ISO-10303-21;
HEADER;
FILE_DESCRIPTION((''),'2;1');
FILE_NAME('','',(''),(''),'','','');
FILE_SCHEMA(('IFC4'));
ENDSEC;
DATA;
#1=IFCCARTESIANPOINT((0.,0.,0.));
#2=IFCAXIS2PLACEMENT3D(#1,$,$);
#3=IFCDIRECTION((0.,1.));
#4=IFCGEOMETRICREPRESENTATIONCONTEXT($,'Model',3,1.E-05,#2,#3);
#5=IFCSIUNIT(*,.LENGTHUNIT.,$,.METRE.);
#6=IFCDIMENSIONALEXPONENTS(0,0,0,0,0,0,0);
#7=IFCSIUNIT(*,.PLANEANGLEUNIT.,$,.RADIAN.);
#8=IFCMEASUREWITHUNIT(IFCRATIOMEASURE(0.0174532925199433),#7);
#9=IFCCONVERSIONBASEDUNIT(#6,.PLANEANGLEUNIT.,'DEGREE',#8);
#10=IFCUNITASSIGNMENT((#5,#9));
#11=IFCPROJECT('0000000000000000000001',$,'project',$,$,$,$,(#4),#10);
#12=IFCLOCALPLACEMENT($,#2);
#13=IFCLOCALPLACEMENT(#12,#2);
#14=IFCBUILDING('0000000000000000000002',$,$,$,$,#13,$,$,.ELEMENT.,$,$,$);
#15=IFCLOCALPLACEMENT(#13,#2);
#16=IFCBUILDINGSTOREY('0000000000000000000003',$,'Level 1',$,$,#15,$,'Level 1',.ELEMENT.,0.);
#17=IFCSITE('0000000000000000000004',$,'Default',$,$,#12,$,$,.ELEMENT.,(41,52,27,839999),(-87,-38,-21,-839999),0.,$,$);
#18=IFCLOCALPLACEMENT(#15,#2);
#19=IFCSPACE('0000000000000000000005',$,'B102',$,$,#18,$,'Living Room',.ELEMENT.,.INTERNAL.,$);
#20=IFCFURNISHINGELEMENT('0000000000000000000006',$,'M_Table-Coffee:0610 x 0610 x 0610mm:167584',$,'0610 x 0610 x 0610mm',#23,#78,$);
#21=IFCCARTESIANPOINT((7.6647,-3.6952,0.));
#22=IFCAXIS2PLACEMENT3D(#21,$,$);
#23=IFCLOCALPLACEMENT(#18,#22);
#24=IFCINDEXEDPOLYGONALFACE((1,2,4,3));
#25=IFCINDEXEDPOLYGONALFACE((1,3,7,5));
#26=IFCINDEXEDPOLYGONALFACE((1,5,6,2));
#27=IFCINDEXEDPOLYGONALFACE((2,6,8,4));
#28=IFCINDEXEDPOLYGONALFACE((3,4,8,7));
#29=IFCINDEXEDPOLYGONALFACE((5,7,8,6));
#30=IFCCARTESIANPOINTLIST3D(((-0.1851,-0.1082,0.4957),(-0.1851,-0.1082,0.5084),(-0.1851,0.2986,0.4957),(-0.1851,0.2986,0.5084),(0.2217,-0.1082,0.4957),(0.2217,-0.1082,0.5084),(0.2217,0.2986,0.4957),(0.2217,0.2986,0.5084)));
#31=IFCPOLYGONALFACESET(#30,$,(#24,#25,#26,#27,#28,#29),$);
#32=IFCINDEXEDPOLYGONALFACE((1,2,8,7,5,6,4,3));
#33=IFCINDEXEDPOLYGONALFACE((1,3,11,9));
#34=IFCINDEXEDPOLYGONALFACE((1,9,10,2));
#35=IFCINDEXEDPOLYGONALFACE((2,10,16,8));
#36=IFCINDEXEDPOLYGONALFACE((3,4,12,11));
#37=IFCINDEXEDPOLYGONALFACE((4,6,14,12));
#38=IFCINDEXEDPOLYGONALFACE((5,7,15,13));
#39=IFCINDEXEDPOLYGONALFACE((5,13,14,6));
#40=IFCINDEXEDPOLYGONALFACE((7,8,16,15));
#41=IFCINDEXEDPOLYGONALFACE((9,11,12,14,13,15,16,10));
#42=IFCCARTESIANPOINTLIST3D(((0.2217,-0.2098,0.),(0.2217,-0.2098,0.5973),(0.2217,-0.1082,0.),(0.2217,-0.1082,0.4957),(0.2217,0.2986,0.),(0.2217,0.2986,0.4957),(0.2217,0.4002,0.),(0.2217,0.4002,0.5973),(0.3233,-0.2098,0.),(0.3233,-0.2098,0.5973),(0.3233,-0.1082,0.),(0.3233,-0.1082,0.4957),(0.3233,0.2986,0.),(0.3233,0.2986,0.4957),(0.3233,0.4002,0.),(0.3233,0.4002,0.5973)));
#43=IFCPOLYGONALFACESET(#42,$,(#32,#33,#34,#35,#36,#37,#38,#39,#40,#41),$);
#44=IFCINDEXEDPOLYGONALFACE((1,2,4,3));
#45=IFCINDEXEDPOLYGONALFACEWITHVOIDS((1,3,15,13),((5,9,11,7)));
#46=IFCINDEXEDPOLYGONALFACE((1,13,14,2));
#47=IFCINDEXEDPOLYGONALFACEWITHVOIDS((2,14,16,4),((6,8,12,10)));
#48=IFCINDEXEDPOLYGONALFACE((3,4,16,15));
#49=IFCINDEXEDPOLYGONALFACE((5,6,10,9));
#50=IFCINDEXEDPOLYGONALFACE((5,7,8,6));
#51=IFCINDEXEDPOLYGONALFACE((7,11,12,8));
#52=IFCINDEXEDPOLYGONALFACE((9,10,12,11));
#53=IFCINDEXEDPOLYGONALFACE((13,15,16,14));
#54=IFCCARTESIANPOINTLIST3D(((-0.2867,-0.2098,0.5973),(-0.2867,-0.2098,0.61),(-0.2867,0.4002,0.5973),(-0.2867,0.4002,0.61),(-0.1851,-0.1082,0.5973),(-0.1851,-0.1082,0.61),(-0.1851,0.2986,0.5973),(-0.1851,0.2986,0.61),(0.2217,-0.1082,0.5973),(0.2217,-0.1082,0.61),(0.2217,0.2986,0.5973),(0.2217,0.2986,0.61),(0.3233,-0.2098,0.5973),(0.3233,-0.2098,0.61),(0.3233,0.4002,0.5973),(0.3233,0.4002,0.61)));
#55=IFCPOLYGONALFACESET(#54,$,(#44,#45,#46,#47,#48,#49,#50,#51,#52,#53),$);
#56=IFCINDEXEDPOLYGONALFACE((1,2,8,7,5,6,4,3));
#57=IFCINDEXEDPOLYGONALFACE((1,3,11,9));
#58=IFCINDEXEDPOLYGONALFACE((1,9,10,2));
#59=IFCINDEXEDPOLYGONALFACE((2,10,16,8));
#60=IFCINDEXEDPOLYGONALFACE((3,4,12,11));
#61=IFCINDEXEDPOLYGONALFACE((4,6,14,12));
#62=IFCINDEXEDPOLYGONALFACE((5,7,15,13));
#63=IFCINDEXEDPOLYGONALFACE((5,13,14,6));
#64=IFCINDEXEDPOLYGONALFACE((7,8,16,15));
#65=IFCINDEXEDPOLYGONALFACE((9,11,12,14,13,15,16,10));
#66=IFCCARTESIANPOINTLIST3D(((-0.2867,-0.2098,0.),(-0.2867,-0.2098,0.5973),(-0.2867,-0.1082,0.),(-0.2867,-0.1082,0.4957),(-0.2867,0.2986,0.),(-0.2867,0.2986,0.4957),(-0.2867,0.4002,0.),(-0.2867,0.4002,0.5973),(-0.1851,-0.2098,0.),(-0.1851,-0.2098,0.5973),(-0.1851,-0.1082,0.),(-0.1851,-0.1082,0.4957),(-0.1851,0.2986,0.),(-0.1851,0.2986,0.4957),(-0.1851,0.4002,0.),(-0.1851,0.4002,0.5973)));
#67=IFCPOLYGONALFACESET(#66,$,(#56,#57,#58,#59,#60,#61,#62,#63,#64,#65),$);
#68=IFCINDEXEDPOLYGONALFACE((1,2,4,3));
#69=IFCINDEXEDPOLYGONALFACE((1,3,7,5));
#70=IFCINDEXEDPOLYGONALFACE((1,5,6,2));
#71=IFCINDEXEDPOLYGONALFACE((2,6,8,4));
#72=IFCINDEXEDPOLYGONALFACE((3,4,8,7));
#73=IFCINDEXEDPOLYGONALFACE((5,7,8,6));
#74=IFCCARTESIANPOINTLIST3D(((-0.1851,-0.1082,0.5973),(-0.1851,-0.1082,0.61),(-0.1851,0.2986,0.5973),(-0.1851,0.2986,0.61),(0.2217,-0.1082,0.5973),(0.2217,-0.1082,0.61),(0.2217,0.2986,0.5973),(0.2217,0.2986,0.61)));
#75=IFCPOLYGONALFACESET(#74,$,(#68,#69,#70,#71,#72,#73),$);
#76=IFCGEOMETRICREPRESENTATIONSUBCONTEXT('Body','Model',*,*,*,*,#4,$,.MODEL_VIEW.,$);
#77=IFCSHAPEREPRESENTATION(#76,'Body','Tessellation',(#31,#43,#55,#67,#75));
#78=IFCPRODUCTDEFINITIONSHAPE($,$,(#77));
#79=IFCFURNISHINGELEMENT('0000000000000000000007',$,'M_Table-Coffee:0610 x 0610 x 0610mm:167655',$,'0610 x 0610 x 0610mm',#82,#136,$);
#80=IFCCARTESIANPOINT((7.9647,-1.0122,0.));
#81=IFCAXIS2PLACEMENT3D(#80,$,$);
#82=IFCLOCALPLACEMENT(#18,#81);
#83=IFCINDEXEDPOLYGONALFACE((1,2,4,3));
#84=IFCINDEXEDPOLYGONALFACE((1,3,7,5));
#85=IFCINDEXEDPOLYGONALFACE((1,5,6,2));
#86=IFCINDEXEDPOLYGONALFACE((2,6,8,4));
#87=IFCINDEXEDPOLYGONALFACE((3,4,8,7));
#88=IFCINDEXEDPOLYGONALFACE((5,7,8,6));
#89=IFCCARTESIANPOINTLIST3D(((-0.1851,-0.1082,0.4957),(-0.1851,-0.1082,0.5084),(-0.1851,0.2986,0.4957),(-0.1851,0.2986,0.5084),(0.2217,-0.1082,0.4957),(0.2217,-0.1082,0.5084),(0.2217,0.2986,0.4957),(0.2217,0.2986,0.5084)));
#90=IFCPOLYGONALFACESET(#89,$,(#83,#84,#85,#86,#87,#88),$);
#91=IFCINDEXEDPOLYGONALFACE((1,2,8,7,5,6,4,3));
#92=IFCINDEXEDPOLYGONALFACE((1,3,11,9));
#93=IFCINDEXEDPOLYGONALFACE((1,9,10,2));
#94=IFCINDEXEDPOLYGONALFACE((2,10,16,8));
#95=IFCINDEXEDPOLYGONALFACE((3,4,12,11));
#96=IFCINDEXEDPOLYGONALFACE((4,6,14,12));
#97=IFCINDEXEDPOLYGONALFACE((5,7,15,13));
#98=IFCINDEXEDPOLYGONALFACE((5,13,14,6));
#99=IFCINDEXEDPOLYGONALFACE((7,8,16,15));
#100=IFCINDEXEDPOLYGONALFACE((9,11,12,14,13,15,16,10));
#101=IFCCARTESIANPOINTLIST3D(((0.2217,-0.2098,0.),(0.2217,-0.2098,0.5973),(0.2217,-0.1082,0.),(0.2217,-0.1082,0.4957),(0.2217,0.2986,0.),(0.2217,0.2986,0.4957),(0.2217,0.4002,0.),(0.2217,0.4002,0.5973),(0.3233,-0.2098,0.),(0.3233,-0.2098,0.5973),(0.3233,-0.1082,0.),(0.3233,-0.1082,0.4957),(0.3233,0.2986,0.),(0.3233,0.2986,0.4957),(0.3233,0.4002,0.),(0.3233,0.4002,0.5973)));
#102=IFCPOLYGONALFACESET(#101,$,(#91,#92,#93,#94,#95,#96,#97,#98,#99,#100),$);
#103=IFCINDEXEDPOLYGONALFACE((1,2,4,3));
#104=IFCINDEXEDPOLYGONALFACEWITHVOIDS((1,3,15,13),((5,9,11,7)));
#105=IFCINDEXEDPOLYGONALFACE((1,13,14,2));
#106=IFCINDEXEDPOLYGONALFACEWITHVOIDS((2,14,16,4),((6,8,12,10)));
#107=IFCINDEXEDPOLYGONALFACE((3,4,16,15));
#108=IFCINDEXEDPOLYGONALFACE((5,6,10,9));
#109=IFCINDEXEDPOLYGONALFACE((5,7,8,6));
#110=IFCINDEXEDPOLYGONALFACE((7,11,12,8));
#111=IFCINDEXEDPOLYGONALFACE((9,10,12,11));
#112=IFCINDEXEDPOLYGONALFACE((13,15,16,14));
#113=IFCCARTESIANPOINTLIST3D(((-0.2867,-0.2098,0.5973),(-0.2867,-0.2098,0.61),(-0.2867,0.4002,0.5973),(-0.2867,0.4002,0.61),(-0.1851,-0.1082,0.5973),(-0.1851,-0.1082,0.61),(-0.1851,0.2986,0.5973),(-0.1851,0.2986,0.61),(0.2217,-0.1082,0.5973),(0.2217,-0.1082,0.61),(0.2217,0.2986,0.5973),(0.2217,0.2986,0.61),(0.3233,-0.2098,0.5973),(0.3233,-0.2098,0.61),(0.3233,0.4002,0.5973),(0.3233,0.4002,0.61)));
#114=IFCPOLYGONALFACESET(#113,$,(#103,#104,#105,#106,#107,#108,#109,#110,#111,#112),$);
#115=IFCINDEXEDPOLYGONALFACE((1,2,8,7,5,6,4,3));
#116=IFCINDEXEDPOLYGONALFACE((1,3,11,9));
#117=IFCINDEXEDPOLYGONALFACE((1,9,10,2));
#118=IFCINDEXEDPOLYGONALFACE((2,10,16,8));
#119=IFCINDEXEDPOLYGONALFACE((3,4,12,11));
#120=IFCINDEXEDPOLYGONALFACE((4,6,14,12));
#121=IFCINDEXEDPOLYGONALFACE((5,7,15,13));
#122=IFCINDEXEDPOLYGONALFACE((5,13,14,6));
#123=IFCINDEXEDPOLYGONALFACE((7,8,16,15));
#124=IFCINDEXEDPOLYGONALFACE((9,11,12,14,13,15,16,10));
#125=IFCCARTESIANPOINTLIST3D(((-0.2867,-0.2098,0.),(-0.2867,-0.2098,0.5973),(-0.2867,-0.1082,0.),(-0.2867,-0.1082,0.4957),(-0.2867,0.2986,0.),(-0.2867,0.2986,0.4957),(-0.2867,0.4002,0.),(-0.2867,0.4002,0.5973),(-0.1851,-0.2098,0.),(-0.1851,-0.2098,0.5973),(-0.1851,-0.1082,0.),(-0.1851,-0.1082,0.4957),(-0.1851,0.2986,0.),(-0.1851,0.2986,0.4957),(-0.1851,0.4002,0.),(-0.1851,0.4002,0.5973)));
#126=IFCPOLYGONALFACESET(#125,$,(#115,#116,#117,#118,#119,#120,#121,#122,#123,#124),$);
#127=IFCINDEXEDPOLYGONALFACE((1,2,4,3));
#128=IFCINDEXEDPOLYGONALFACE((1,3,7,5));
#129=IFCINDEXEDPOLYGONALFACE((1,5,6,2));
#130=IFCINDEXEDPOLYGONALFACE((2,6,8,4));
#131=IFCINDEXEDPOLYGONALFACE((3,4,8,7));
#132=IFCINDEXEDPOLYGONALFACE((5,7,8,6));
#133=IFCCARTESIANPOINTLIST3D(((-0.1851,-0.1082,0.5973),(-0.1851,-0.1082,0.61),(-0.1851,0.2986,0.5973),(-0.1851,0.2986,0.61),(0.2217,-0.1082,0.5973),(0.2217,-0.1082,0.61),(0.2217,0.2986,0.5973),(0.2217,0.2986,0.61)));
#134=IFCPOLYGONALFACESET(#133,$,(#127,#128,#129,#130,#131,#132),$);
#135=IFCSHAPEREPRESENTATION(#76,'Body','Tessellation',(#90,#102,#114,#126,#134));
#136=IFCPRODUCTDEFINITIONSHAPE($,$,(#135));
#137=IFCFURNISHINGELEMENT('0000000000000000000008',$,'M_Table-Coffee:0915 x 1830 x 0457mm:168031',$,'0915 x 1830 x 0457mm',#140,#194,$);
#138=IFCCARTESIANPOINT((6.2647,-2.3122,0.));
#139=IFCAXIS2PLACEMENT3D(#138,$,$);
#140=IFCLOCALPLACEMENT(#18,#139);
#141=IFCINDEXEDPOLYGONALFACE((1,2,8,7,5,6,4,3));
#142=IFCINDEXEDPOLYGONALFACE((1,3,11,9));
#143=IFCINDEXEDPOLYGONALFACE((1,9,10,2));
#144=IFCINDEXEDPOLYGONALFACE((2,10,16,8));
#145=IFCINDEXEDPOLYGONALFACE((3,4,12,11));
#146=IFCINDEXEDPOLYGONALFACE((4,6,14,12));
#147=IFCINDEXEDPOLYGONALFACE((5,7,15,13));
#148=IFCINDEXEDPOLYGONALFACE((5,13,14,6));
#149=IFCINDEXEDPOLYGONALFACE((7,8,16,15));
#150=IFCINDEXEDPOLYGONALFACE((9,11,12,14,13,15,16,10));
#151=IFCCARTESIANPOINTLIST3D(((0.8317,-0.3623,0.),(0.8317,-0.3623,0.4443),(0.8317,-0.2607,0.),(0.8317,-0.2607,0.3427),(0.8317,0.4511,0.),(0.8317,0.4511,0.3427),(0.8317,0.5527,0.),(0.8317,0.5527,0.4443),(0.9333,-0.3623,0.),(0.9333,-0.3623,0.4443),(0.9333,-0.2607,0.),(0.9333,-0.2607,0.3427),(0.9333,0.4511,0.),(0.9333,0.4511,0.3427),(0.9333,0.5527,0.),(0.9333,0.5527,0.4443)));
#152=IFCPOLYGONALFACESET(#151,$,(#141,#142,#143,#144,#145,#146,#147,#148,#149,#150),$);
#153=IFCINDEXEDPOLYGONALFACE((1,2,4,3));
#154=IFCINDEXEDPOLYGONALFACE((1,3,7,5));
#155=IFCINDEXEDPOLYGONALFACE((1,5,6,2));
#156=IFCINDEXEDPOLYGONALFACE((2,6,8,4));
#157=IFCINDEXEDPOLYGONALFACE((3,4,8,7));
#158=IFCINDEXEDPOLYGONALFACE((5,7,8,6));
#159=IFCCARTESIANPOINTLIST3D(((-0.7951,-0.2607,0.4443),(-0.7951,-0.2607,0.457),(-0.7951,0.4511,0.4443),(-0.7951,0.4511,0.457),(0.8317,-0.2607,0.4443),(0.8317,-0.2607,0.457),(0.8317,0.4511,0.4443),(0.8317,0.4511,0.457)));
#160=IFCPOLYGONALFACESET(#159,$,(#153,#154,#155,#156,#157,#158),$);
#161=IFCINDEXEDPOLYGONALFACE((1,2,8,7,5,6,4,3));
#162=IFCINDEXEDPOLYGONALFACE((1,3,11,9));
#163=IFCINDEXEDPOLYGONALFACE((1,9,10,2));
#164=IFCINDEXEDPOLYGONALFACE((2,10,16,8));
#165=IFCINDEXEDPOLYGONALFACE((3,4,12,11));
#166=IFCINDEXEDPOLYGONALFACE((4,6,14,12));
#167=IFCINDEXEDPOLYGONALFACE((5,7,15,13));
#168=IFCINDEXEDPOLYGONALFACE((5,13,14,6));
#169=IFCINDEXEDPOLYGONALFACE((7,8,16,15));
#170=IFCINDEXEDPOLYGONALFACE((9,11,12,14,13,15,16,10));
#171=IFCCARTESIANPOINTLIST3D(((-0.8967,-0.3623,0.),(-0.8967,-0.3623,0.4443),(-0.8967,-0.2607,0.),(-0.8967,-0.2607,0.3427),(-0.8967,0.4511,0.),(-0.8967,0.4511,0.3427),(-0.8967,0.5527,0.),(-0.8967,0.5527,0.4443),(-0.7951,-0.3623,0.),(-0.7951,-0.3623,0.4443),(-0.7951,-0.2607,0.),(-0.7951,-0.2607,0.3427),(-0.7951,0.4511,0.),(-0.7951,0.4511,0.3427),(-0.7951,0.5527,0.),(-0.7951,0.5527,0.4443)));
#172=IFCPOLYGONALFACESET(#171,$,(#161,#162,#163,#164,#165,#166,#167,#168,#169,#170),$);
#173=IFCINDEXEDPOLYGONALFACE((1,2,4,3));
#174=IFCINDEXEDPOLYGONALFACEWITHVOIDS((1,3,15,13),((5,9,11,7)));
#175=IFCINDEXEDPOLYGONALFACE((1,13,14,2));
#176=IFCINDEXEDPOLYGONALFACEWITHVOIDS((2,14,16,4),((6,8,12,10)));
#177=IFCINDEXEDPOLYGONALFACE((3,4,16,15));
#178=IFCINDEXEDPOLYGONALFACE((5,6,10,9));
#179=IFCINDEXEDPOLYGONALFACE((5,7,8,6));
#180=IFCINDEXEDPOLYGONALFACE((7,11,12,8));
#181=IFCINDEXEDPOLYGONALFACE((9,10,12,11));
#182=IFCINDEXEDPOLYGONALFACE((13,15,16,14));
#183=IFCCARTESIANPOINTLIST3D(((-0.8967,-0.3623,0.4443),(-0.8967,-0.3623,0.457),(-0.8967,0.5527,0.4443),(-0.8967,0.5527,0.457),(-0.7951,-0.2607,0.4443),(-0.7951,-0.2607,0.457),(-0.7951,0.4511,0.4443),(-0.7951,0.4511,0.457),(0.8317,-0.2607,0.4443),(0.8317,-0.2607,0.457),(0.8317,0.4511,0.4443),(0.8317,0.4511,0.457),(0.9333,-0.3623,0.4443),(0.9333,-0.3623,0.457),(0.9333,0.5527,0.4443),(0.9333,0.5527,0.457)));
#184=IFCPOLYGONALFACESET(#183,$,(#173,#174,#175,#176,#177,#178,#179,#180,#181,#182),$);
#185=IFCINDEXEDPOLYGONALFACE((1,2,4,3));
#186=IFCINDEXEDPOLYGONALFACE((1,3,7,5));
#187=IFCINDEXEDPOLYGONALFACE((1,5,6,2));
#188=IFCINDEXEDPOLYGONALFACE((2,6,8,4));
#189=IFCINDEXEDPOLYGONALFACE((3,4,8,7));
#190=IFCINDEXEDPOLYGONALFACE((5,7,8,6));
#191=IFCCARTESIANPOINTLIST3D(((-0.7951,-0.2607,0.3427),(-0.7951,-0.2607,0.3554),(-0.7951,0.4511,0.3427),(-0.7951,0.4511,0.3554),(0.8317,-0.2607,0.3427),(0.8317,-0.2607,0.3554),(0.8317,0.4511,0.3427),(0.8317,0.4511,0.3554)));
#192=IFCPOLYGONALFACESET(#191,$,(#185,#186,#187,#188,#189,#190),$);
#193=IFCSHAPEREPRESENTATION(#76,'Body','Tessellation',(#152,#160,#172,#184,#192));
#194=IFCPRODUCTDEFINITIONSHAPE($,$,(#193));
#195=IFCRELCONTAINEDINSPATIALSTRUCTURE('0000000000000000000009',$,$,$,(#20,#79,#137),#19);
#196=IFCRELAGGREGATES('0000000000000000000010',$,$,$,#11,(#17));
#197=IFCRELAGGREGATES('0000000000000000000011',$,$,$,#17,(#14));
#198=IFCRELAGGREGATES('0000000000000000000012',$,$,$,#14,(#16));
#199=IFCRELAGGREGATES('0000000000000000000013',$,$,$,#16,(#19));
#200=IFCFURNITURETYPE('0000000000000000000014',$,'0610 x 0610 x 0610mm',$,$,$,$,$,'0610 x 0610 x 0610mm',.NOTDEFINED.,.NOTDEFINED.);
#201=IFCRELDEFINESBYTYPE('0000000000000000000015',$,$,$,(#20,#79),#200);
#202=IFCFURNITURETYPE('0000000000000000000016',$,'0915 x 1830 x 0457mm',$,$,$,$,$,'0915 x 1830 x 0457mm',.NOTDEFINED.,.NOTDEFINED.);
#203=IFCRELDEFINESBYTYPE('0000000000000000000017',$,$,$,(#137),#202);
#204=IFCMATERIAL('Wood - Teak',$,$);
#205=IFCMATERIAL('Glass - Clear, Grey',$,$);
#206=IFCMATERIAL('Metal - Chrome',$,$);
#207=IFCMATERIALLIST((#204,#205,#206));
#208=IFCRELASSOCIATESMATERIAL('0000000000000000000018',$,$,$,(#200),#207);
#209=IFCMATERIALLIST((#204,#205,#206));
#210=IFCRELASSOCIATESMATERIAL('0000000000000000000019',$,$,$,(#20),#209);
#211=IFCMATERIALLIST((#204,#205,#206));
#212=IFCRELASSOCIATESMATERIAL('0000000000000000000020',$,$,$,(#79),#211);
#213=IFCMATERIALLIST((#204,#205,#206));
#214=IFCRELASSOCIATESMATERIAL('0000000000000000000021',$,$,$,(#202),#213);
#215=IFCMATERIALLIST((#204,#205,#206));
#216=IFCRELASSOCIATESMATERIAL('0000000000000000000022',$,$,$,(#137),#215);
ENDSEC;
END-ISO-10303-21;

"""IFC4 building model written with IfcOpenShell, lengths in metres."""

from ifc_helpers import new_model, entity, si_unit, converted_unit, direction, frame, origin, origin_2d_with_axis, place, context, subcontext, project, spatial, polyline, rectangle, outline, extrude, source, transform, mapped, material, material_list, type_object, type_shapes, element, save


model = new_model("IFC4")

# Units and contexts
model_context = context("Model", 3, precision=1e-05, world=origin(), true_north=direction((0.0, 1.0)))
body_context = subcontext(model_context, "Body", "Model", "MODEL_VIEW")
ifc_project = project(units=[si_unit("LENGTHUNIT", "METRE"), converted_unit("PLANEANGLEUNIT", "DEGREE", entity("IfcRatioMeasure", 0.0174532925199433), si_unit("PLANEANGLEUNIT", "RADIAN"), dimensions=[0, 0, 0, 0, 0, 0, 0])], contexts=[model_context])

# Site, building, storey
site_placement = place(None, origin())
site = spatial("IfcSite", under=ifc_project, at=site_placement, Name="Default", CompositionType="ELEMENT", RefLatitude=(41, 52, 27, 839999), RefLongitude=(-87, -38, -21, -839999), RefElevation=0.0)
building_placement = place(site_placement, origin())
building = spatial("IfcBuilding", under=site, at=building_placement, CompositionType="ELEMENT")
storey_placement = place(building_placement, origin())
storey = spatial("IfcBuildingStorey", under=building, at=storey_placement, Name="Level 1", LongName="Level 1", CompositionType="ELEMENT", Elevation=0.0)

# Shared definitions
space_1_placement = place(storey_placement, origin())
space_1 = spatial("IfcSpace", under=storey, at=space_1_placement, Name="B102", LongName="Living Room", CompositionType="ELEMENT", PredefinedType="INTERNAL")

# Furnishing elements
ifc_material_1 = material(Name="Wood - Teak")
ifc_material_2 = material(Name="Glass - Clear, Grey")
ifc_material_3 = material(Name="Metal - Chrome")
ifc_material_list_1 = material_list([ifc_material_1, ifc_material_2, ifc_material_3])
ifc_material_list_2 = material_list([ifc_material_1, ifc_material_2, ifc_material_3])
furniture_type_1 = type_object("IfcFurnitureType", Name="0610 x 0610 x 0610mm", ElementType="0610 x 0610 x 0610mm", AssemblyPlace="NOTDEFINED", material=ifc_material_list_2)
shared_shape_1 = source(origin(), body_context, "Body", "SweptSolid", [
    extrude(rectangle(XDim=0.4068, YDim=0.4068, at=origin_2d_with_axis()), frame((0.0183, 0.0952, 0.4957), z_axis=(0.0, 0.0, 1.0), x_axis=(-1.0, 0.0, 0.0)), (0.0, 0.0, 1.0), 0.0127),
    extrude(outline(polyline([(-0.2732, -0.305), (0.324, -0.305), (0.324, 0.305), (-0.2732, 0.305), (-0.2732, 0.2034), (0.2225, 0.2034), (0.2225, -0.2034), (-0.2732, -0.2034), (-0.2732, -0.305)])), frame((0.2217, 0.0952, 0.2732), z_axis=(1.0, 0.0, 0.0), x_axis=(0.0, 0.0, 1.0)), (0.0, 0.0, 1.0), 0.1016),
    extrude(outline(polyline([(-0.305, -0.305), (0.305, -0.305), (0.305, 0.305), (-0.305, 0.305), (-0.305, -0.305)]), holes=[polyline([(-0.2034, -0.2034), (-0.2034, 0.2034), (0.2034, 0.2034), (0.2034, -0.2034), (-0.2034, -0.2034)])]), frame((0.0183, 0.0952, 0.5973), z_axis=(0.0, 0.0, 1.0), x_axis=(-1.0, 0.0, 0.0)), (0.0, 0.0, 1.0), 0.0127),
    extrude(outline(polyline([(-0.305, -0.3241), (0.305, -0.3241), (0.305, 0.2733), (0.2034, 0.2733), (0.2034, -0.2224), (-0.2034, -0.2224), (-0.2034, 0.2733), (-0.305, 0.2733), (-0.305, -0.3241)])), frame((-0.2867, 0.0952, 0.2733), z_axis=(1.0, 0.0, 0.0), x_axis=(0.0, -1.0, 0.0)), (0.0, 0.0, 1.0), 0.1016),
    extrude(rectangle(XDim=0.4068, YDim=0.4068, at=origin_2d_with_axis()), frame((0.0183, 0.0952, 0.5973), z_axis=(0.0, 0.0, 1.0), x_axis=(-1.0, 0.0, 0.0)), (0.0, 0.0, 1.0), 0.0127),
])
type_shapes(furniture_type_1, [shared_shape_1])
furnishing_1_placement = place(space_1_placement, frame((7.6647, -3.6952, 0.0)))
element("IfcFurnishingElement", 1, at=furnishing_1_placement, inside=space_1, type_object=furniture_type_1, material=ifc_material_list_1, Name="M_Table-Coffee:0610 x 0610 x 0610mm:167584", ObjectType="0610 x 0610 x 0610mm", context=body_context, shape_type="MappedRepresentation", body=[
    mapped(shared_shape_1, transform((0.0, 0.0, 0.0), scale=1.0)),
])
ifc_material_list_3 = material_list([ifc_material_1, ifc_material_2, ifc_material_3])
furnishing_2_placement = place(space_1_placement, frame((7.9647, -1.0122, 0.0)))
element("IfcFurnishingElement", 2, at=furnishing_2_placement, inside=space_1, type_object=furniture_type_1, material=ifc_material_list_3, Name="M_Table-Coffee:0610 x 0610 x 0610mm:167655", ObjectType="0610 x 0610 x 0610mm", context=body_context, shape_type="MappedRepresentation", body=[
    mapped(shared_shape_1, transform((0.0, 0.0, 0.0), scale=1.0)),
])
ifc_material_list_4 = material_list([ifc_material_1, ifc_material_2, ifc_material_3])
ifc_material_list_5 = material_list([ifc_material_1, ifc_material_2, ifc_material_3])
furniture_type_2 = type_object("IfcFurnitureType", Name="0915 x 1830 x 0457mm", ElementType="0915 x 1830 x 0457mm", AssemblyPlace="NOTDEFINED", material=ifc_material_list_5)
shared_shape_2 = source(origin(), body_context, "Body", "SweptSolid", [
    extrude(outline(polyline([(-0.1967, -0.4575), (0.2475, -0.4575), (0.2475, 0.4575), (-0.1967, 0.4575), (-0.1967, 0.3559), (0.146, 0.3559), (0.146, -0.3559), (-0.1967, -0.3559), (-0.1967, -0.4575)])), frame((0.8317, 0.0952, 0.1967), z_axis=(1.0, 0.0, 0.0), x_axis=(0.0, 0.0, 1.0)), (0.0, 0.0, 1.0), 0.1016),
    extrude(rectangle(XDim=1.6268, YDim=0.7118, at=origin_2d_with_axis()), frame((0.0183, 0.0952, 0.4443), z_axis=(0.0, 0.0, 1.0), x_axis=(-1.0, 0.0, 0.0)), (0.0, 0.0, 1.0), 0.0127),
    extrude(outline(polyline([(-0.4575, -0.2476), (0.4575, -0.2476), (0.4575, 0.1968), (0.3559, 0.1968), (0.3559, -0.1459), (-0.3559, -0.1459), (-0.3559, 0.1968), (-0.4575, 0.1968), (-0.4575, -0.2476)])), frame((-0.8967, 0.0952, 0.1968), z_axis=(1.0, 0.0, 0.0), x_axis=(0.0, -1.0, 0.0)), (0.0, 0.0, 1.0), 0.1016),
    extrude(outline(polyline([(-0.915, -0.4575), (0.915, -0.4575), (0.915, 0.4575), (-0.915, 0.4575), (-0.915, -0.4575)]), holes=[polyline([(-0.8134, -0.3559), (-0.8134, 0.3559), (0.8134, 0.3559), (0.8134, -0.3559), (-0.8134, -0.3559)])]), frame((0.0183, 0.0952, 0.4443), z_axis=(0.0, 0.0, 1.0), x_axis=(-1.0, 0.0, 0.0)), (0.0, 0.0, 1.0), 0.0127),
    extrude(rectangle(XDim=1.6268, YDim=0.7118, at=origin_2d_with_axis()), frame((0.0183, 0.0952, 0.3427), z_axis=(0.0, 0.0, 1.0), x_axis=(-1.0, 0.0, 0.0)), (0.0, 0.0, 1.0), 0.0127),
])
type_shapes(furniture_type_2, [shared_shape_2])
furnishing_3_placement = place(space_1_placement, frame((6.2647, -2.3122, 0.0)))
element("IfcFurnishingElement", 3, at=furnishing_3_placement, inside=space_1, type_object=furniture_type_2, material=ifc_material_list_4, Name="M_Table-Coffee:0915 x 1830 x 0457mm:168031", ObjectType="0915 x 1830 x 0457mm", context=body_context, shape_type="MappedRepresentation", body=[
    mapped(shared_shape_2, transform((0.0, 0.0, 0.0), scale=1.0)),
])

save(model, "model.ifc")
